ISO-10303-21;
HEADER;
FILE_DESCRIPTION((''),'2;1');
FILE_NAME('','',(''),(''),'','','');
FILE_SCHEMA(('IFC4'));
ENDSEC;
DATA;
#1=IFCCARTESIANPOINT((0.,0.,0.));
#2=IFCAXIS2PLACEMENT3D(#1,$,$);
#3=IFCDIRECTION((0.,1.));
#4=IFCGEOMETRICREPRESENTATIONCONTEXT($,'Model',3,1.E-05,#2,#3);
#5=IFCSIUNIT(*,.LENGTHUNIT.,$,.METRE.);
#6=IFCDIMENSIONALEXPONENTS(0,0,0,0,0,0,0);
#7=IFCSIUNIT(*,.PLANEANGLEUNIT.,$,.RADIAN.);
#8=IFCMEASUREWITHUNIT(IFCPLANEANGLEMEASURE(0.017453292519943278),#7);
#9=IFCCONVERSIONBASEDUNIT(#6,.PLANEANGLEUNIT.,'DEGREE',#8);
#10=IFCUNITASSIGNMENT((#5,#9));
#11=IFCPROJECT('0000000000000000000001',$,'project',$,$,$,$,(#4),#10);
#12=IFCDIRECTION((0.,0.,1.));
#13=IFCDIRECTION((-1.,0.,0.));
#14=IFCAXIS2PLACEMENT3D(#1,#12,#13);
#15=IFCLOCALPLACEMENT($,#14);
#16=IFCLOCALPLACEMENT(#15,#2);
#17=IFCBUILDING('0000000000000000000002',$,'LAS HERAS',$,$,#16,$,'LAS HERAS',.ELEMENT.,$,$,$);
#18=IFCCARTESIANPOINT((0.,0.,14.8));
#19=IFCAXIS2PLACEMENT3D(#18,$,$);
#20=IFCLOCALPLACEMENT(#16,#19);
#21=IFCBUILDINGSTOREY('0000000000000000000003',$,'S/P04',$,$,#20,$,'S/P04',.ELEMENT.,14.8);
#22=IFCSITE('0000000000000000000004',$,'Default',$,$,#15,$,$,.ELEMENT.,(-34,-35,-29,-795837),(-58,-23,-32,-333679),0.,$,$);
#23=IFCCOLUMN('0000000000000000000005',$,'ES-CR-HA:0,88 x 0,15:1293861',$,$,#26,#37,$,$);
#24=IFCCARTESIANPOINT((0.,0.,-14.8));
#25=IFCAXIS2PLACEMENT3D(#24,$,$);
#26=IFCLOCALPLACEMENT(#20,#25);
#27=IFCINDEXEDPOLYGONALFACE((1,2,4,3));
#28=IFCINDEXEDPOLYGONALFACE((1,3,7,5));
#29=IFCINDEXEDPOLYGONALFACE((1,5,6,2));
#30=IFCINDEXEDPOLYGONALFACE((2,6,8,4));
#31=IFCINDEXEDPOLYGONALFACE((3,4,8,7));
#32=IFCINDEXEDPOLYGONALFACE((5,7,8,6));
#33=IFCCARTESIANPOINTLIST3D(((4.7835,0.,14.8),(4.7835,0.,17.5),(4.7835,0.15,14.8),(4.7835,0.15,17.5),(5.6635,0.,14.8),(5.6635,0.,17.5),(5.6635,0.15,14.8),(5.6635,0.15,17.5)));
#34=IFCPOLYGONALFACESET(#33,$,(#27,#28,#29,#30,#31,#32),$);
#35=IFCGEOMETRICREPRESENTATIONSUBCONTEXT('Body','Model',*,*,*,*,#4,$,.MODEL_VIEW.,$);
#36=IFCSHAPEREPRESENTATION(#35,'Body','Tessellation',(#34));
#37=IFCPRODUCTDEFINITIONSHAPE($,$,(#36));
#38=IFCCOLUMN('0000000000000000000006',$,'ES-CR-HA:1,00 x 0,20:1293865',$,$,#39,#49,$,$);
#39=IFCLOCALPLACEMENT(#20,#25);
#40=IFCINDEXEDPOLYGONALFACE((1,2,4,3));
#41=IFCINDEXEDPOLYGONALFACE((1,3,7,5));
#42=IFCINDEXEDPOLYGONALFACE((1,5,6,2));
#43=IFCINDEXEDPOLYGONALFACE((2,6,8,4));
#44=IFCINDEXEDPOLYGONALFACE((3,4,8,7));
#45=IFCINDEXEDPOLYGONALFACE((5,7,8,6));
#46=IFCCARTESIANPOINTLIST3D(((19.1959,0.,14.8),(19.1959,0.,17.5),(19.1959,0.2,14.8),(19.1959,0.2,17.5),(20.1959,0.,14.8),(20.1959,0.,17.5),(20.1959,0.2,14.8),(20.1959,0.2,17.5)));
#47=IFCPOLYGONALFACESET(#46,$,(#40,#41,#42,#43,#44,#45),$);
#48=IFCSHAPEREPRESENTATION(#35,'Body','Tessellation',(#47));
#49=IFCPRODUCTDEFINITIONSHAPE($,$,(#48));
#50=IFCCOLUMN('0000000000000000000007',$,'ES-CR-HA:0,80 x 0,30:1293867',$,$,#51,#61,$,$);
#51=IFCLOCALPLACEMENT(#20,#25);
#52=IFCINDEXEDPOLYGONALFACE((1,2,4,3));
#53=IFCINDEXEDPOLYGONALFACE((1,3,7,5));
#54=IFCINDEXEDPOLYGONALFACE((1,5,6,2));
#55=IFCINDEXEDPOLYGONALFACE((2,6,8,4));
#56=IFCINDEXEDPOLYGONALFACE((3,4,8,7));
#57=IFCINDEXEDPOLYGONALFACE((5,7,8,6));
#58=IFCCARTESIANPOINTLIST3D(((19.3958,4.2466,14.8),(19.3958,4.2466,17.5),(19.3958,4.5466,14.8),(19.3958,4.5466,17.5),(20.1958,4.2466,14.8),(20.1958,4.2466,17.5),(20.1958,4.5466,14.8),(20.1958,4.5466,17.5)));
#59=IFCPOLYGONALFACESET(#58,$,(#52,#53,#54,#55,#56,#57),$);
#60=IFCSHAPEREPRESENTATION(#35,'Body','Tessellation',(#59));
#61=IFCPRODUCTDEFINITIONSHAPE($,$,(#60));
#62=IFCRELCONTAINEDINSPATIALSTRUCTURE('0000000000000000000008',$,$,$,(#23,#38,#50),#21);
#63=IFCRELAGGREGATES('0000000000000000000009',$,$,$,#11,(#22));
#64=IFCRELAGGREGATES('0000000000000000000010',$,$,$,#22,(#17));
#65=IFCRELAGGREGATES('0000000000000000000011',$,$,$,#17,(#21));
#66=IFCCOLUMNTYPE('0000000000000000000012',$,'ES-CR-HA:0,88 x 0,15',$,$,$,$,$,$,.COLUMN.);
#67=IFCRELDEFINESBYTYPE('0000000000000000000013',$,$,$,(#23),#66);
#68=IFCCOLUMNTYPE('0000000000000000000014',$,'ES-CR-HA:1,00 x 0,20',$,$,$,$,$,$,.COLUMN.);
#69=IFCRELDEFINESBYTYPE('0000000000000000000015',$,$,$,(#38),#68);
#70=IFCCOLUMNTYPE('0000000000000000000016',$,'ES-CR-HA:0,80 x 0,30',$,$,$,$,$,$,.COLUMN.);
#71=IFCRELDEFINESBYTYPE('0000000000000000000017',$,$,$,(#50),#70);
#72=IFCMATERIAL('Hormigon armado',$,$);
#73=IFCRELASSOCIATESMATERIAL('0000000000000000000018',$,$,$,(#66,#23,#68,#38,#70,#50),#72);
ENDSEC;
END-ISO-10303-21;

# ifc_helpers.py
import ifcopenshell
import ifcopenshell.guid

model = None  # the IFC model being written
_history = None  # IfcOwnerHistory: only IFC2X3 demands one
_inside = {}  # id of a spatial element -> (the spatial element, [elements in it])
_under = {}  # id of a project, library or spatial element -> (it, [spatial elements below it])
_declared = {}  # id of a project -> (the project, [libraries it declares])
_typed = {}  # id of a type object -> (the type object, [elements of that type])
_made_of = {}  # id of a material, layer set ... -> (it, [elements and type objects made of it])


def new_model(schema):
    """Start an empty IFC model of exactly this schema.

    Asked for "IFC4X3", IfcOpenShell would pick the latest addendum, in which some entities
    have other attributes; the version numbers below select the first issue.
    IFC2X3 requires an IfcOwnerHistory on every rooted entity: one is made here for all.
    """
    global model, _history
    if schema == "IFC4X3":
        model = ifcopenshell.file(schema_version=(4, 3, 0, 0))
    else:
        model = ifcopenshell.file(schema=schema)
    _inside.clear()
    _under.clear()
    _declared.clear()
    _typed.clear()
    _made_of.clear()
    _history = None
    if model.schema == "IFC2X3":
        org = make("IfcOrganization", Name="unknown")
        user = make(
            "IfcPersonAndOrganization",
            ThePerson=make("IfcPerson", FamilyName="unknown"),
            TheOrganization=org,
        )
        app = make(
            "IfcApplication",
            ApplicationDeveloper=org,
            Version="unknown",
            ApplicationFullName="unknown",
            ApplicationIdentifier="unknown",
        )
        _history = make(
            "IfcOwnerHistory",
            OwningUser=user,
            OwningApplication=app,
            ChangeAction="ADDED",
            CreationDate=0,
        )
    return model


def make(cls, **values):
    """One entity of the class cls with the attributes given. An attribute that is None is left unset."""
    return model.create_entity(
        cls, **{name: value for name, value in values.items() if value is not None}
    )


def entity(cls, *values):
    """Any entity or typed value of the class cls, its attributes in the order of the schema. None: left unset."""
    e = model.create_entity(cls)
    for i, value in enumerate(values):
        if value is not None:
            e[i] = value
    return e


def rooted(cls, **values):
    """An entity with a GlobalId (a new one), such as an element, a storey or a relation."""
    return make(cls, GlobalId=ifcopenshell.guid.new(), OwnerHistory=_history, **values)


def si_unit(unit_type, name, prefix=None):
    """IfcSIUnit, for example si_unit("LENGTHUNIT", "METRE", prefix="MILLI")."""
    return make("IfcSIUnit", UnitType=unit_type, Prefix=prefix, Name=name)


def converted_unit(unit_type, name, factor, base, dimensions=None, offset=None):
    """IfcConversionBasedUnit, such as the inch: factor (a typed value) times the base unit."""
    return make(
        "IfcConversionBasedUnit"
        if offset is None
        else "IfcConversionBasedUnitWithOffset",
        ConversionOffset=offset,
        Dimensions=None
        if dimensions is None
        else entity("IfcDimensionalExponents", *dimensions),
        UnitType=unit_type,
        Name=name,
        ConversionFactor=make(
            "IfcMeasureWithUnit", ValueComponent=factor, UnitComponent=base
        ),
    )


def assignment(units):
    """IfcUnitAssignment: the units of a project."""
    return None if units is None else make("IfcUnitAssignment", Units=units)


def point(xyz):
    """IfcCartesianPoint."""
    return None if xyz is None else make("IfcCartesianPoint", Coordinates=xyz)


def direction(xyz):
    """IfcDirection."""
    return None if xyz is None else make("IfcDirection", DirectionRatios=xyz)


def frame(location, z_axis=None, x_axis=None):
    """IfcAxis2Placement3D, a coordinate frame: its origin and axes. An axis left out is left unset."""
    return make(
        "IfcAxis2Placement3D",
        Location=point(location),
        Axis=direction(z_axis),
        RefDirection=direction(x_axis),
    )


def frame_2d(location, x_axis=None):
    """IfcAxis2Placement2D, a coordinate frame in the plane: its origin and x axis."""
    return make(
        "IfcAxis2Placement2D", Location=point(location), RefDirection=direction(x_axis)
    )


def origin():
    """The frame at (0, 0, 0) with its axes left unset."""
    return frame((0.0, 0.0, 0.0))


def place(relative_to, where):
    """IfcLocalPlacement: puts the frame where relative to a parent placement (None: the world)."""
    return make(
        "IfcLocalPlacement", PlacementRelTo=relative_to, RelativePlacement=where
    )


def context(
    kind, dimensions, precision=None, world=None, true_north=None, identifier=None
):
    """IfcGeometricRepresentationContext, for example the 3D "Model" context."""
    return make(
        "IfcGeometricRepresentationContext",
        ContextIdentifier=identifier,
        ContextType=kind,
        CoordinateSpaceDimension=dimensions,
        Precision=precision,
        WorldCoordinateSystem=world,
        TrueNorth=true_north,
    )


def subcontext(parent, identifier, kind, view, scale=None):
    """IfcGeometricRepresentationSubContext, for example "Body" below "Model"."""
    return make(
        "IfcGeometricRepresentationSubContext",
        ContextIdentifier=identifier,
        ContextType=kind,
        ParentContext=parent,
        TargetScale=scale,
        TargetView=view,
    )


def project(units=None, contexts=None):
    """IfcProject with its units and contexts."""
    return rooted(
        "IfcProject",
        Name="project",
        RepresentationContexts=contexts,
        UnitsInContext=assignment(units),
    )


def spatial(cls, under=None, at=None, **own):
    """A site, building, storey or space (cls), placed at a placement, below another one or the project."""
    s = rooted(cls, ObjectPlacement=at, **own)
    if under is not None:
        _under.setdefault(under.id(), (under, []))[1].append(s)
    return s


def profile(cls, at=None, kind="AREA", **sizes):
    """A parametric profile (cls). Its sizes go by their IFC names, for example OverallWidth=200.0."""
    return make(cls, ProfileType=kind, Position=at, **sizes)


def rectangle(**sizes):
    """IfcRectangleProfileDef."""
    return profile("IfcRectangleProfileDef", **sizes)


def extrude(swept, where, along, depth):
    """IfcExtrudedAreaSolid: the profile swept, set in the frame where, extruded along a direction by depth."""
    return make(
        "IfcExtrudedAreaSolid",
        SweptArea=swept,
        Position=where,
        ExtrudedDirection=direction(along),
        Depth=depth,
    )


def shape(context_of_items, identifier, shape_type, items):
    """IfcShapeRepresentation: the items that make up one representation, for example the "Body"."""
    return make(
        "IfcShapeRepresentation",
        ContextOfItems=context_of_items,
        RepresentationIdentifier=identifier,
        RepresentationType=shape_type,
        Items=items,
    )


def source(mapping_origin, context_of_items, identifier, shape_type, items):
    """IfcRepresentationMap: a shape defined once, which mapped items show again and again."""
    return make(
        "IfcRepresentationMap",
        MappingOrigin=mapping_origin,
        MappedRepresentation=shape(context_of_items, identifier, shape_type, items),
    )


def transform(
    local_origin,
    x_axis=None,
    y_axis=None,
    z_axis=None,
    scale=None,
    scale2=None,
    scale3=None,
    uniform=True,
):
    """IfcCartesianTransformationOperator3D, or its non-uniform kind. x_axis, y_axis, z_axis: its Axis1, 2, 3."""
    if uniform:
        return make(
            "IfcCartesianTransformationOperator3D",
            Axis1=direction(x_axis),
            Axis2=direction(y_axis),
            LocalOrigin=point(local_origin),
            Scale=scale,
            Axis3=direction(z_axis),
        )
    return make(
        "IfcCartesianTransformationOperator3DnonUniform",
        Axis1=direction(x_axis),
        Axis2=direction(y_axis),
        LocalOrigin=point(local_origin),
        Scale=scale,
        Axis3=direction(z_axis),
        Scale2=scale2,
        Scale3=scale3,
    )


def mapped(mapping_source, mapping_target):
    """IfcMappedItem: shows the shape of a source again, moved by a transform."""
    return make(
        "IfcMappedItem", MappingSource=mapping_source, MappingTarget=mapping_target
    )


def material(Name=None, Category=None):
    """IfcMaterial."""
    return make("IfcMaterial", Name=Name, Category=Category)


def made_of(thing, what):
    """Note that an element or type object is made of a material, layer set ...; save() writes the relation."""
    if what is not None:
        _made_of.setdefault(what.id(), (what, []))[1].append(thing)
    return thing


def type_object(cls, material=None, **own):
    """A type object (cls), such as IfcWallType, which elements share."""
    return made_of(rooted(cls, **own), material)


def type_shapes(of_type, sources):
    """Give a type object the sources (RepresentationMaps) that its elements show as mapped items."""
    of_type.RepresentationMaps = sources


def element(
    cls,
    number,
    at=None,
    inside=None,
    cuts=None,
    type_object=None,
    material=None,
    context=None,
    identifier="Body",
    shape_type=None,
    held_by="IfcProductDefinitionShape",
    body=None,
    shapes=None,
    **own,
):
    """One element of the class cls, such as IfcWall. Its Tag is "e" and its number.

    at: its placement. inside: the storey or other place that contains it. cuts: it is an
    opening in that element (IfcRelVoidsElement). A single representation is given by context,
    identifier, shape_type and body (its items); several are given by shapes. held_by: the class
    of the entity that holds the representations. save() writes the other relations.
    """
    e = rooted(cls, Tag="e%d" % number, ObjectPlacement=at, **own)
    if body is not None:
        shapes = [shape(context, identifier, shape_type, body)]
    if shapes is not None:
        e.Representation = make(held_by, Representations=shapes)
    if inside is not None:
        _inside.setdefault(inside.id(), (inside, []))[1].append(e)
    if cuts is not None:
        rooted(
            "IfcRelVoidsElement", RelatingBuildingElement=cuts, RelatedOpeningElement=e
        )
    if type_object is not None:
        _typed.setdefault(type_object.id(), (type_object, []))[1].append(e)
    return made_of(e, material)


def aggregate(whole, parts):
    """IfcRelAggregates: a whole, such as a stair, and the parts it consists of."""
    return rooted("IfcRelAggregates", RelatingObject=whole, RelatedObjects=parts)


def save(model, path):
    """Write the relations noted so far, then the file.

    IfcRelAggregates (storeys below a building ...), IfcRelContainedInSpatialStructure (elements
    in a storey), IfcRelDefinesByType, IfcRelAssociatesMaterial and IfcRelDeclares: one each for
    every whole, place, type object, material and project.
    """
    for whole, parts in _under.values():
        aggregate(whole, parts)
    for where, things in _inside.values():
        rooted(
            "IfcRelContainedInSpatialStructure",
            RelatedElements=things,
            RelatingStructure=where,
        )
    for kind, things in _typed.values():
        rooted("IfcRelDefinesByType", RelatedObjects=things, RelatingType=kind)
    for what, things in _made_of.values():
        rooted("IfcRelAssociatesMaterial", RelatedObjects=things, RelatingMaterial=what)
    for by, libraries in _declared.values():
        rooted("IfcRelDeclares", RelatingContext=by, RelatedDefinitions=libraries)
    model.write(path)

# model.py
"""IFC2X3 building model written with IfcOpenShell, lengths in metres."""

from ifc_helpers import new_model, entity, si_unit, converted_unit, direction, frame, frame_2d, origin, place, context, subcontext, project, spatial, rectangle, extrude, source, transform, mapped, material, type_object, type_shapes, element, save


model = new_model("IFC2X3")

# Units and contexts
model_context = context("Model", 3, precision=1e-05, world=origin(), true_north=direction((0.0, 1.0)))
body_context = subcontext(model_context, "Body", "Model", "MODEL_VIEW")
ifc_project = project(units=[si_unit("LENGTHUNIT", "METRE"), converted_unit("PLANEANGLEUNIT", "DEGREE", entity("IfcPlaneAngleMeasure", 0.017453292519943278), si_unit("PLANEANGLEUNIT", "RADIAN"), dimensions=[0, 0, 0, 0, 0, 0, 0])], contexts=[model_context])

# Site, building, storey
site_placement = place(None, frame((0.0, 0.0, 0.0), z_axis=(0.0, 0.0, 1.0), x_axis=(-1.0, 0.0, 0.0)))
site = spatial("IfcSite", under=ifc_project, at=site_placement, Name="Default", CompositionType="ELEMENT", RefLatitude=(-34, -35, -29, -795837), RefLongitude=(-58, -23, -32, -333679), RefElevation=0.0)
building_placement = place(site_placement, origin())
building = spatial("IfcBuilding", under=site, at=building_placement, Name="LAS HERAS", LongName="LAS HERAS", CompositionType="ELEMENT")
storey_placement = place(building_placement, frame((0.0, 0.0, 14.8)))
storey = spatial("IfcBuildingStorey", under=building, at=storey_placement, Name="S/P04", LongName="S/P04", CompositionType="ELEMENT", Elevation=14.8)

# Columns
ifc_material = material(Name="Hormigon armado")
column_type_1 = type_object("IfcColumnType", Name="ES-CR-HA:0,88 x 0,15", PredefinedType="COLUMN", material=ifc_material)
shared_shape_1 = source(origin(), body_context, "Body", "SweptSolid", [
    extrude(rectangle(XDim=2.7, YDim=0.15, at=frame_2d((0.0, 0.0), x_axis=(1.0, 0.0))), frame((4.7835, 0.075, 16.15), z_axis=(1.0, 0.0, 0.0), x_axis=(0.0, 0.0, 1.0)), (0.0, 0.0, 1.0), 0.88),
])
type_shapes(column_type_1, [shared_shape_1])
column_1_placement = place(storey_placement, frame((0.0, 0.0, -14.8)))
element("IfcColumn", 1, at=column_1_placement, inside=storey, type_object=column_type_1, material=ifc_material, Name="ES-CR-HA:0,88 x 0,15:1293861", context=body_context, shape_type="MappedRepresentation", body=[
    mapped(shared_shape_1, transform((0.0, 0.0, 0.0), scale=1.0)),
])
column_type_2 = type_object("IfcColumnType", Name="ES-CR-HA:1,00 x 0,20", PredefinedType="COLUMN", material=ifc_material)
shared_shape_2 = source(origin(), body_context, "Body", "SweptSolid", [
    extrude(rectangle(XDim=2.7, YDim=0.2, at=frame_2d((0.0, 0.0), x_axis=(1.0, 0.0))), frame((19.1959, 0.1, 16.15), z_axis=(1.0, 0.0, 0.0), x_axis=(0.0, 0.0, 1.0)), (0.0, 0.0, 1.0), 1.0),
])
type_shapes(column_type_2, [shared_shape_2])
column_2_placement = place(storey_placement, frame((0.0, 0.0, -14.8)))
element("IfcColumn", 2, at=column_2_placement, inside=storey, type_object=column_type_2, material=ifc_material, Name="ES-CR-HA:1,00 x 0,20:1293865", context=body_context, shape_type="MappedRepresentation", body=[
    mapped(shared_shape_2, transform((0.0, 0.0, 0.0), scale=1.0)),
])
column_type_3 = type_object("IfcColumnType", Name="ES-CR-HA:0,80 x 0,30", PredefinedType="COLUMN", material=ifc_material)
shared_shape_3 = source(origin(), body_context, "Body", "SweptSolid", [
    extrude(rectangle(XDim=2.7, YDim=0.3, at=frame_2d((0.0, 0.0), x_axis=(1.0, 0.0))), frame((19.3958, 4.3966, 16.15), z_axis=(1.0, 0.0, 0.0), x_axis=(0.0, 0.0, 1.0)), (0.0, 0.0, 1.0), 0.8),
])
type_shapes(column_type_3, [shared_shape_3])
column_3_placement = place(storey_placement, frame((0.0, 0.0, -14.8)))
element("IfcColumn", 3, at=column_3_placement, inside=storey, type_object=column_type_3, material=ifc_material, Name="ES-CR-HA:0,80 x 0,30:1293867", context=body_context, shape_type="MappedRepresentation", body=[
    mapped(shared_shape_3, transform((0.0, 0.0, 0.0), scale=1.0)),
])

save(model, "model.ifc")
